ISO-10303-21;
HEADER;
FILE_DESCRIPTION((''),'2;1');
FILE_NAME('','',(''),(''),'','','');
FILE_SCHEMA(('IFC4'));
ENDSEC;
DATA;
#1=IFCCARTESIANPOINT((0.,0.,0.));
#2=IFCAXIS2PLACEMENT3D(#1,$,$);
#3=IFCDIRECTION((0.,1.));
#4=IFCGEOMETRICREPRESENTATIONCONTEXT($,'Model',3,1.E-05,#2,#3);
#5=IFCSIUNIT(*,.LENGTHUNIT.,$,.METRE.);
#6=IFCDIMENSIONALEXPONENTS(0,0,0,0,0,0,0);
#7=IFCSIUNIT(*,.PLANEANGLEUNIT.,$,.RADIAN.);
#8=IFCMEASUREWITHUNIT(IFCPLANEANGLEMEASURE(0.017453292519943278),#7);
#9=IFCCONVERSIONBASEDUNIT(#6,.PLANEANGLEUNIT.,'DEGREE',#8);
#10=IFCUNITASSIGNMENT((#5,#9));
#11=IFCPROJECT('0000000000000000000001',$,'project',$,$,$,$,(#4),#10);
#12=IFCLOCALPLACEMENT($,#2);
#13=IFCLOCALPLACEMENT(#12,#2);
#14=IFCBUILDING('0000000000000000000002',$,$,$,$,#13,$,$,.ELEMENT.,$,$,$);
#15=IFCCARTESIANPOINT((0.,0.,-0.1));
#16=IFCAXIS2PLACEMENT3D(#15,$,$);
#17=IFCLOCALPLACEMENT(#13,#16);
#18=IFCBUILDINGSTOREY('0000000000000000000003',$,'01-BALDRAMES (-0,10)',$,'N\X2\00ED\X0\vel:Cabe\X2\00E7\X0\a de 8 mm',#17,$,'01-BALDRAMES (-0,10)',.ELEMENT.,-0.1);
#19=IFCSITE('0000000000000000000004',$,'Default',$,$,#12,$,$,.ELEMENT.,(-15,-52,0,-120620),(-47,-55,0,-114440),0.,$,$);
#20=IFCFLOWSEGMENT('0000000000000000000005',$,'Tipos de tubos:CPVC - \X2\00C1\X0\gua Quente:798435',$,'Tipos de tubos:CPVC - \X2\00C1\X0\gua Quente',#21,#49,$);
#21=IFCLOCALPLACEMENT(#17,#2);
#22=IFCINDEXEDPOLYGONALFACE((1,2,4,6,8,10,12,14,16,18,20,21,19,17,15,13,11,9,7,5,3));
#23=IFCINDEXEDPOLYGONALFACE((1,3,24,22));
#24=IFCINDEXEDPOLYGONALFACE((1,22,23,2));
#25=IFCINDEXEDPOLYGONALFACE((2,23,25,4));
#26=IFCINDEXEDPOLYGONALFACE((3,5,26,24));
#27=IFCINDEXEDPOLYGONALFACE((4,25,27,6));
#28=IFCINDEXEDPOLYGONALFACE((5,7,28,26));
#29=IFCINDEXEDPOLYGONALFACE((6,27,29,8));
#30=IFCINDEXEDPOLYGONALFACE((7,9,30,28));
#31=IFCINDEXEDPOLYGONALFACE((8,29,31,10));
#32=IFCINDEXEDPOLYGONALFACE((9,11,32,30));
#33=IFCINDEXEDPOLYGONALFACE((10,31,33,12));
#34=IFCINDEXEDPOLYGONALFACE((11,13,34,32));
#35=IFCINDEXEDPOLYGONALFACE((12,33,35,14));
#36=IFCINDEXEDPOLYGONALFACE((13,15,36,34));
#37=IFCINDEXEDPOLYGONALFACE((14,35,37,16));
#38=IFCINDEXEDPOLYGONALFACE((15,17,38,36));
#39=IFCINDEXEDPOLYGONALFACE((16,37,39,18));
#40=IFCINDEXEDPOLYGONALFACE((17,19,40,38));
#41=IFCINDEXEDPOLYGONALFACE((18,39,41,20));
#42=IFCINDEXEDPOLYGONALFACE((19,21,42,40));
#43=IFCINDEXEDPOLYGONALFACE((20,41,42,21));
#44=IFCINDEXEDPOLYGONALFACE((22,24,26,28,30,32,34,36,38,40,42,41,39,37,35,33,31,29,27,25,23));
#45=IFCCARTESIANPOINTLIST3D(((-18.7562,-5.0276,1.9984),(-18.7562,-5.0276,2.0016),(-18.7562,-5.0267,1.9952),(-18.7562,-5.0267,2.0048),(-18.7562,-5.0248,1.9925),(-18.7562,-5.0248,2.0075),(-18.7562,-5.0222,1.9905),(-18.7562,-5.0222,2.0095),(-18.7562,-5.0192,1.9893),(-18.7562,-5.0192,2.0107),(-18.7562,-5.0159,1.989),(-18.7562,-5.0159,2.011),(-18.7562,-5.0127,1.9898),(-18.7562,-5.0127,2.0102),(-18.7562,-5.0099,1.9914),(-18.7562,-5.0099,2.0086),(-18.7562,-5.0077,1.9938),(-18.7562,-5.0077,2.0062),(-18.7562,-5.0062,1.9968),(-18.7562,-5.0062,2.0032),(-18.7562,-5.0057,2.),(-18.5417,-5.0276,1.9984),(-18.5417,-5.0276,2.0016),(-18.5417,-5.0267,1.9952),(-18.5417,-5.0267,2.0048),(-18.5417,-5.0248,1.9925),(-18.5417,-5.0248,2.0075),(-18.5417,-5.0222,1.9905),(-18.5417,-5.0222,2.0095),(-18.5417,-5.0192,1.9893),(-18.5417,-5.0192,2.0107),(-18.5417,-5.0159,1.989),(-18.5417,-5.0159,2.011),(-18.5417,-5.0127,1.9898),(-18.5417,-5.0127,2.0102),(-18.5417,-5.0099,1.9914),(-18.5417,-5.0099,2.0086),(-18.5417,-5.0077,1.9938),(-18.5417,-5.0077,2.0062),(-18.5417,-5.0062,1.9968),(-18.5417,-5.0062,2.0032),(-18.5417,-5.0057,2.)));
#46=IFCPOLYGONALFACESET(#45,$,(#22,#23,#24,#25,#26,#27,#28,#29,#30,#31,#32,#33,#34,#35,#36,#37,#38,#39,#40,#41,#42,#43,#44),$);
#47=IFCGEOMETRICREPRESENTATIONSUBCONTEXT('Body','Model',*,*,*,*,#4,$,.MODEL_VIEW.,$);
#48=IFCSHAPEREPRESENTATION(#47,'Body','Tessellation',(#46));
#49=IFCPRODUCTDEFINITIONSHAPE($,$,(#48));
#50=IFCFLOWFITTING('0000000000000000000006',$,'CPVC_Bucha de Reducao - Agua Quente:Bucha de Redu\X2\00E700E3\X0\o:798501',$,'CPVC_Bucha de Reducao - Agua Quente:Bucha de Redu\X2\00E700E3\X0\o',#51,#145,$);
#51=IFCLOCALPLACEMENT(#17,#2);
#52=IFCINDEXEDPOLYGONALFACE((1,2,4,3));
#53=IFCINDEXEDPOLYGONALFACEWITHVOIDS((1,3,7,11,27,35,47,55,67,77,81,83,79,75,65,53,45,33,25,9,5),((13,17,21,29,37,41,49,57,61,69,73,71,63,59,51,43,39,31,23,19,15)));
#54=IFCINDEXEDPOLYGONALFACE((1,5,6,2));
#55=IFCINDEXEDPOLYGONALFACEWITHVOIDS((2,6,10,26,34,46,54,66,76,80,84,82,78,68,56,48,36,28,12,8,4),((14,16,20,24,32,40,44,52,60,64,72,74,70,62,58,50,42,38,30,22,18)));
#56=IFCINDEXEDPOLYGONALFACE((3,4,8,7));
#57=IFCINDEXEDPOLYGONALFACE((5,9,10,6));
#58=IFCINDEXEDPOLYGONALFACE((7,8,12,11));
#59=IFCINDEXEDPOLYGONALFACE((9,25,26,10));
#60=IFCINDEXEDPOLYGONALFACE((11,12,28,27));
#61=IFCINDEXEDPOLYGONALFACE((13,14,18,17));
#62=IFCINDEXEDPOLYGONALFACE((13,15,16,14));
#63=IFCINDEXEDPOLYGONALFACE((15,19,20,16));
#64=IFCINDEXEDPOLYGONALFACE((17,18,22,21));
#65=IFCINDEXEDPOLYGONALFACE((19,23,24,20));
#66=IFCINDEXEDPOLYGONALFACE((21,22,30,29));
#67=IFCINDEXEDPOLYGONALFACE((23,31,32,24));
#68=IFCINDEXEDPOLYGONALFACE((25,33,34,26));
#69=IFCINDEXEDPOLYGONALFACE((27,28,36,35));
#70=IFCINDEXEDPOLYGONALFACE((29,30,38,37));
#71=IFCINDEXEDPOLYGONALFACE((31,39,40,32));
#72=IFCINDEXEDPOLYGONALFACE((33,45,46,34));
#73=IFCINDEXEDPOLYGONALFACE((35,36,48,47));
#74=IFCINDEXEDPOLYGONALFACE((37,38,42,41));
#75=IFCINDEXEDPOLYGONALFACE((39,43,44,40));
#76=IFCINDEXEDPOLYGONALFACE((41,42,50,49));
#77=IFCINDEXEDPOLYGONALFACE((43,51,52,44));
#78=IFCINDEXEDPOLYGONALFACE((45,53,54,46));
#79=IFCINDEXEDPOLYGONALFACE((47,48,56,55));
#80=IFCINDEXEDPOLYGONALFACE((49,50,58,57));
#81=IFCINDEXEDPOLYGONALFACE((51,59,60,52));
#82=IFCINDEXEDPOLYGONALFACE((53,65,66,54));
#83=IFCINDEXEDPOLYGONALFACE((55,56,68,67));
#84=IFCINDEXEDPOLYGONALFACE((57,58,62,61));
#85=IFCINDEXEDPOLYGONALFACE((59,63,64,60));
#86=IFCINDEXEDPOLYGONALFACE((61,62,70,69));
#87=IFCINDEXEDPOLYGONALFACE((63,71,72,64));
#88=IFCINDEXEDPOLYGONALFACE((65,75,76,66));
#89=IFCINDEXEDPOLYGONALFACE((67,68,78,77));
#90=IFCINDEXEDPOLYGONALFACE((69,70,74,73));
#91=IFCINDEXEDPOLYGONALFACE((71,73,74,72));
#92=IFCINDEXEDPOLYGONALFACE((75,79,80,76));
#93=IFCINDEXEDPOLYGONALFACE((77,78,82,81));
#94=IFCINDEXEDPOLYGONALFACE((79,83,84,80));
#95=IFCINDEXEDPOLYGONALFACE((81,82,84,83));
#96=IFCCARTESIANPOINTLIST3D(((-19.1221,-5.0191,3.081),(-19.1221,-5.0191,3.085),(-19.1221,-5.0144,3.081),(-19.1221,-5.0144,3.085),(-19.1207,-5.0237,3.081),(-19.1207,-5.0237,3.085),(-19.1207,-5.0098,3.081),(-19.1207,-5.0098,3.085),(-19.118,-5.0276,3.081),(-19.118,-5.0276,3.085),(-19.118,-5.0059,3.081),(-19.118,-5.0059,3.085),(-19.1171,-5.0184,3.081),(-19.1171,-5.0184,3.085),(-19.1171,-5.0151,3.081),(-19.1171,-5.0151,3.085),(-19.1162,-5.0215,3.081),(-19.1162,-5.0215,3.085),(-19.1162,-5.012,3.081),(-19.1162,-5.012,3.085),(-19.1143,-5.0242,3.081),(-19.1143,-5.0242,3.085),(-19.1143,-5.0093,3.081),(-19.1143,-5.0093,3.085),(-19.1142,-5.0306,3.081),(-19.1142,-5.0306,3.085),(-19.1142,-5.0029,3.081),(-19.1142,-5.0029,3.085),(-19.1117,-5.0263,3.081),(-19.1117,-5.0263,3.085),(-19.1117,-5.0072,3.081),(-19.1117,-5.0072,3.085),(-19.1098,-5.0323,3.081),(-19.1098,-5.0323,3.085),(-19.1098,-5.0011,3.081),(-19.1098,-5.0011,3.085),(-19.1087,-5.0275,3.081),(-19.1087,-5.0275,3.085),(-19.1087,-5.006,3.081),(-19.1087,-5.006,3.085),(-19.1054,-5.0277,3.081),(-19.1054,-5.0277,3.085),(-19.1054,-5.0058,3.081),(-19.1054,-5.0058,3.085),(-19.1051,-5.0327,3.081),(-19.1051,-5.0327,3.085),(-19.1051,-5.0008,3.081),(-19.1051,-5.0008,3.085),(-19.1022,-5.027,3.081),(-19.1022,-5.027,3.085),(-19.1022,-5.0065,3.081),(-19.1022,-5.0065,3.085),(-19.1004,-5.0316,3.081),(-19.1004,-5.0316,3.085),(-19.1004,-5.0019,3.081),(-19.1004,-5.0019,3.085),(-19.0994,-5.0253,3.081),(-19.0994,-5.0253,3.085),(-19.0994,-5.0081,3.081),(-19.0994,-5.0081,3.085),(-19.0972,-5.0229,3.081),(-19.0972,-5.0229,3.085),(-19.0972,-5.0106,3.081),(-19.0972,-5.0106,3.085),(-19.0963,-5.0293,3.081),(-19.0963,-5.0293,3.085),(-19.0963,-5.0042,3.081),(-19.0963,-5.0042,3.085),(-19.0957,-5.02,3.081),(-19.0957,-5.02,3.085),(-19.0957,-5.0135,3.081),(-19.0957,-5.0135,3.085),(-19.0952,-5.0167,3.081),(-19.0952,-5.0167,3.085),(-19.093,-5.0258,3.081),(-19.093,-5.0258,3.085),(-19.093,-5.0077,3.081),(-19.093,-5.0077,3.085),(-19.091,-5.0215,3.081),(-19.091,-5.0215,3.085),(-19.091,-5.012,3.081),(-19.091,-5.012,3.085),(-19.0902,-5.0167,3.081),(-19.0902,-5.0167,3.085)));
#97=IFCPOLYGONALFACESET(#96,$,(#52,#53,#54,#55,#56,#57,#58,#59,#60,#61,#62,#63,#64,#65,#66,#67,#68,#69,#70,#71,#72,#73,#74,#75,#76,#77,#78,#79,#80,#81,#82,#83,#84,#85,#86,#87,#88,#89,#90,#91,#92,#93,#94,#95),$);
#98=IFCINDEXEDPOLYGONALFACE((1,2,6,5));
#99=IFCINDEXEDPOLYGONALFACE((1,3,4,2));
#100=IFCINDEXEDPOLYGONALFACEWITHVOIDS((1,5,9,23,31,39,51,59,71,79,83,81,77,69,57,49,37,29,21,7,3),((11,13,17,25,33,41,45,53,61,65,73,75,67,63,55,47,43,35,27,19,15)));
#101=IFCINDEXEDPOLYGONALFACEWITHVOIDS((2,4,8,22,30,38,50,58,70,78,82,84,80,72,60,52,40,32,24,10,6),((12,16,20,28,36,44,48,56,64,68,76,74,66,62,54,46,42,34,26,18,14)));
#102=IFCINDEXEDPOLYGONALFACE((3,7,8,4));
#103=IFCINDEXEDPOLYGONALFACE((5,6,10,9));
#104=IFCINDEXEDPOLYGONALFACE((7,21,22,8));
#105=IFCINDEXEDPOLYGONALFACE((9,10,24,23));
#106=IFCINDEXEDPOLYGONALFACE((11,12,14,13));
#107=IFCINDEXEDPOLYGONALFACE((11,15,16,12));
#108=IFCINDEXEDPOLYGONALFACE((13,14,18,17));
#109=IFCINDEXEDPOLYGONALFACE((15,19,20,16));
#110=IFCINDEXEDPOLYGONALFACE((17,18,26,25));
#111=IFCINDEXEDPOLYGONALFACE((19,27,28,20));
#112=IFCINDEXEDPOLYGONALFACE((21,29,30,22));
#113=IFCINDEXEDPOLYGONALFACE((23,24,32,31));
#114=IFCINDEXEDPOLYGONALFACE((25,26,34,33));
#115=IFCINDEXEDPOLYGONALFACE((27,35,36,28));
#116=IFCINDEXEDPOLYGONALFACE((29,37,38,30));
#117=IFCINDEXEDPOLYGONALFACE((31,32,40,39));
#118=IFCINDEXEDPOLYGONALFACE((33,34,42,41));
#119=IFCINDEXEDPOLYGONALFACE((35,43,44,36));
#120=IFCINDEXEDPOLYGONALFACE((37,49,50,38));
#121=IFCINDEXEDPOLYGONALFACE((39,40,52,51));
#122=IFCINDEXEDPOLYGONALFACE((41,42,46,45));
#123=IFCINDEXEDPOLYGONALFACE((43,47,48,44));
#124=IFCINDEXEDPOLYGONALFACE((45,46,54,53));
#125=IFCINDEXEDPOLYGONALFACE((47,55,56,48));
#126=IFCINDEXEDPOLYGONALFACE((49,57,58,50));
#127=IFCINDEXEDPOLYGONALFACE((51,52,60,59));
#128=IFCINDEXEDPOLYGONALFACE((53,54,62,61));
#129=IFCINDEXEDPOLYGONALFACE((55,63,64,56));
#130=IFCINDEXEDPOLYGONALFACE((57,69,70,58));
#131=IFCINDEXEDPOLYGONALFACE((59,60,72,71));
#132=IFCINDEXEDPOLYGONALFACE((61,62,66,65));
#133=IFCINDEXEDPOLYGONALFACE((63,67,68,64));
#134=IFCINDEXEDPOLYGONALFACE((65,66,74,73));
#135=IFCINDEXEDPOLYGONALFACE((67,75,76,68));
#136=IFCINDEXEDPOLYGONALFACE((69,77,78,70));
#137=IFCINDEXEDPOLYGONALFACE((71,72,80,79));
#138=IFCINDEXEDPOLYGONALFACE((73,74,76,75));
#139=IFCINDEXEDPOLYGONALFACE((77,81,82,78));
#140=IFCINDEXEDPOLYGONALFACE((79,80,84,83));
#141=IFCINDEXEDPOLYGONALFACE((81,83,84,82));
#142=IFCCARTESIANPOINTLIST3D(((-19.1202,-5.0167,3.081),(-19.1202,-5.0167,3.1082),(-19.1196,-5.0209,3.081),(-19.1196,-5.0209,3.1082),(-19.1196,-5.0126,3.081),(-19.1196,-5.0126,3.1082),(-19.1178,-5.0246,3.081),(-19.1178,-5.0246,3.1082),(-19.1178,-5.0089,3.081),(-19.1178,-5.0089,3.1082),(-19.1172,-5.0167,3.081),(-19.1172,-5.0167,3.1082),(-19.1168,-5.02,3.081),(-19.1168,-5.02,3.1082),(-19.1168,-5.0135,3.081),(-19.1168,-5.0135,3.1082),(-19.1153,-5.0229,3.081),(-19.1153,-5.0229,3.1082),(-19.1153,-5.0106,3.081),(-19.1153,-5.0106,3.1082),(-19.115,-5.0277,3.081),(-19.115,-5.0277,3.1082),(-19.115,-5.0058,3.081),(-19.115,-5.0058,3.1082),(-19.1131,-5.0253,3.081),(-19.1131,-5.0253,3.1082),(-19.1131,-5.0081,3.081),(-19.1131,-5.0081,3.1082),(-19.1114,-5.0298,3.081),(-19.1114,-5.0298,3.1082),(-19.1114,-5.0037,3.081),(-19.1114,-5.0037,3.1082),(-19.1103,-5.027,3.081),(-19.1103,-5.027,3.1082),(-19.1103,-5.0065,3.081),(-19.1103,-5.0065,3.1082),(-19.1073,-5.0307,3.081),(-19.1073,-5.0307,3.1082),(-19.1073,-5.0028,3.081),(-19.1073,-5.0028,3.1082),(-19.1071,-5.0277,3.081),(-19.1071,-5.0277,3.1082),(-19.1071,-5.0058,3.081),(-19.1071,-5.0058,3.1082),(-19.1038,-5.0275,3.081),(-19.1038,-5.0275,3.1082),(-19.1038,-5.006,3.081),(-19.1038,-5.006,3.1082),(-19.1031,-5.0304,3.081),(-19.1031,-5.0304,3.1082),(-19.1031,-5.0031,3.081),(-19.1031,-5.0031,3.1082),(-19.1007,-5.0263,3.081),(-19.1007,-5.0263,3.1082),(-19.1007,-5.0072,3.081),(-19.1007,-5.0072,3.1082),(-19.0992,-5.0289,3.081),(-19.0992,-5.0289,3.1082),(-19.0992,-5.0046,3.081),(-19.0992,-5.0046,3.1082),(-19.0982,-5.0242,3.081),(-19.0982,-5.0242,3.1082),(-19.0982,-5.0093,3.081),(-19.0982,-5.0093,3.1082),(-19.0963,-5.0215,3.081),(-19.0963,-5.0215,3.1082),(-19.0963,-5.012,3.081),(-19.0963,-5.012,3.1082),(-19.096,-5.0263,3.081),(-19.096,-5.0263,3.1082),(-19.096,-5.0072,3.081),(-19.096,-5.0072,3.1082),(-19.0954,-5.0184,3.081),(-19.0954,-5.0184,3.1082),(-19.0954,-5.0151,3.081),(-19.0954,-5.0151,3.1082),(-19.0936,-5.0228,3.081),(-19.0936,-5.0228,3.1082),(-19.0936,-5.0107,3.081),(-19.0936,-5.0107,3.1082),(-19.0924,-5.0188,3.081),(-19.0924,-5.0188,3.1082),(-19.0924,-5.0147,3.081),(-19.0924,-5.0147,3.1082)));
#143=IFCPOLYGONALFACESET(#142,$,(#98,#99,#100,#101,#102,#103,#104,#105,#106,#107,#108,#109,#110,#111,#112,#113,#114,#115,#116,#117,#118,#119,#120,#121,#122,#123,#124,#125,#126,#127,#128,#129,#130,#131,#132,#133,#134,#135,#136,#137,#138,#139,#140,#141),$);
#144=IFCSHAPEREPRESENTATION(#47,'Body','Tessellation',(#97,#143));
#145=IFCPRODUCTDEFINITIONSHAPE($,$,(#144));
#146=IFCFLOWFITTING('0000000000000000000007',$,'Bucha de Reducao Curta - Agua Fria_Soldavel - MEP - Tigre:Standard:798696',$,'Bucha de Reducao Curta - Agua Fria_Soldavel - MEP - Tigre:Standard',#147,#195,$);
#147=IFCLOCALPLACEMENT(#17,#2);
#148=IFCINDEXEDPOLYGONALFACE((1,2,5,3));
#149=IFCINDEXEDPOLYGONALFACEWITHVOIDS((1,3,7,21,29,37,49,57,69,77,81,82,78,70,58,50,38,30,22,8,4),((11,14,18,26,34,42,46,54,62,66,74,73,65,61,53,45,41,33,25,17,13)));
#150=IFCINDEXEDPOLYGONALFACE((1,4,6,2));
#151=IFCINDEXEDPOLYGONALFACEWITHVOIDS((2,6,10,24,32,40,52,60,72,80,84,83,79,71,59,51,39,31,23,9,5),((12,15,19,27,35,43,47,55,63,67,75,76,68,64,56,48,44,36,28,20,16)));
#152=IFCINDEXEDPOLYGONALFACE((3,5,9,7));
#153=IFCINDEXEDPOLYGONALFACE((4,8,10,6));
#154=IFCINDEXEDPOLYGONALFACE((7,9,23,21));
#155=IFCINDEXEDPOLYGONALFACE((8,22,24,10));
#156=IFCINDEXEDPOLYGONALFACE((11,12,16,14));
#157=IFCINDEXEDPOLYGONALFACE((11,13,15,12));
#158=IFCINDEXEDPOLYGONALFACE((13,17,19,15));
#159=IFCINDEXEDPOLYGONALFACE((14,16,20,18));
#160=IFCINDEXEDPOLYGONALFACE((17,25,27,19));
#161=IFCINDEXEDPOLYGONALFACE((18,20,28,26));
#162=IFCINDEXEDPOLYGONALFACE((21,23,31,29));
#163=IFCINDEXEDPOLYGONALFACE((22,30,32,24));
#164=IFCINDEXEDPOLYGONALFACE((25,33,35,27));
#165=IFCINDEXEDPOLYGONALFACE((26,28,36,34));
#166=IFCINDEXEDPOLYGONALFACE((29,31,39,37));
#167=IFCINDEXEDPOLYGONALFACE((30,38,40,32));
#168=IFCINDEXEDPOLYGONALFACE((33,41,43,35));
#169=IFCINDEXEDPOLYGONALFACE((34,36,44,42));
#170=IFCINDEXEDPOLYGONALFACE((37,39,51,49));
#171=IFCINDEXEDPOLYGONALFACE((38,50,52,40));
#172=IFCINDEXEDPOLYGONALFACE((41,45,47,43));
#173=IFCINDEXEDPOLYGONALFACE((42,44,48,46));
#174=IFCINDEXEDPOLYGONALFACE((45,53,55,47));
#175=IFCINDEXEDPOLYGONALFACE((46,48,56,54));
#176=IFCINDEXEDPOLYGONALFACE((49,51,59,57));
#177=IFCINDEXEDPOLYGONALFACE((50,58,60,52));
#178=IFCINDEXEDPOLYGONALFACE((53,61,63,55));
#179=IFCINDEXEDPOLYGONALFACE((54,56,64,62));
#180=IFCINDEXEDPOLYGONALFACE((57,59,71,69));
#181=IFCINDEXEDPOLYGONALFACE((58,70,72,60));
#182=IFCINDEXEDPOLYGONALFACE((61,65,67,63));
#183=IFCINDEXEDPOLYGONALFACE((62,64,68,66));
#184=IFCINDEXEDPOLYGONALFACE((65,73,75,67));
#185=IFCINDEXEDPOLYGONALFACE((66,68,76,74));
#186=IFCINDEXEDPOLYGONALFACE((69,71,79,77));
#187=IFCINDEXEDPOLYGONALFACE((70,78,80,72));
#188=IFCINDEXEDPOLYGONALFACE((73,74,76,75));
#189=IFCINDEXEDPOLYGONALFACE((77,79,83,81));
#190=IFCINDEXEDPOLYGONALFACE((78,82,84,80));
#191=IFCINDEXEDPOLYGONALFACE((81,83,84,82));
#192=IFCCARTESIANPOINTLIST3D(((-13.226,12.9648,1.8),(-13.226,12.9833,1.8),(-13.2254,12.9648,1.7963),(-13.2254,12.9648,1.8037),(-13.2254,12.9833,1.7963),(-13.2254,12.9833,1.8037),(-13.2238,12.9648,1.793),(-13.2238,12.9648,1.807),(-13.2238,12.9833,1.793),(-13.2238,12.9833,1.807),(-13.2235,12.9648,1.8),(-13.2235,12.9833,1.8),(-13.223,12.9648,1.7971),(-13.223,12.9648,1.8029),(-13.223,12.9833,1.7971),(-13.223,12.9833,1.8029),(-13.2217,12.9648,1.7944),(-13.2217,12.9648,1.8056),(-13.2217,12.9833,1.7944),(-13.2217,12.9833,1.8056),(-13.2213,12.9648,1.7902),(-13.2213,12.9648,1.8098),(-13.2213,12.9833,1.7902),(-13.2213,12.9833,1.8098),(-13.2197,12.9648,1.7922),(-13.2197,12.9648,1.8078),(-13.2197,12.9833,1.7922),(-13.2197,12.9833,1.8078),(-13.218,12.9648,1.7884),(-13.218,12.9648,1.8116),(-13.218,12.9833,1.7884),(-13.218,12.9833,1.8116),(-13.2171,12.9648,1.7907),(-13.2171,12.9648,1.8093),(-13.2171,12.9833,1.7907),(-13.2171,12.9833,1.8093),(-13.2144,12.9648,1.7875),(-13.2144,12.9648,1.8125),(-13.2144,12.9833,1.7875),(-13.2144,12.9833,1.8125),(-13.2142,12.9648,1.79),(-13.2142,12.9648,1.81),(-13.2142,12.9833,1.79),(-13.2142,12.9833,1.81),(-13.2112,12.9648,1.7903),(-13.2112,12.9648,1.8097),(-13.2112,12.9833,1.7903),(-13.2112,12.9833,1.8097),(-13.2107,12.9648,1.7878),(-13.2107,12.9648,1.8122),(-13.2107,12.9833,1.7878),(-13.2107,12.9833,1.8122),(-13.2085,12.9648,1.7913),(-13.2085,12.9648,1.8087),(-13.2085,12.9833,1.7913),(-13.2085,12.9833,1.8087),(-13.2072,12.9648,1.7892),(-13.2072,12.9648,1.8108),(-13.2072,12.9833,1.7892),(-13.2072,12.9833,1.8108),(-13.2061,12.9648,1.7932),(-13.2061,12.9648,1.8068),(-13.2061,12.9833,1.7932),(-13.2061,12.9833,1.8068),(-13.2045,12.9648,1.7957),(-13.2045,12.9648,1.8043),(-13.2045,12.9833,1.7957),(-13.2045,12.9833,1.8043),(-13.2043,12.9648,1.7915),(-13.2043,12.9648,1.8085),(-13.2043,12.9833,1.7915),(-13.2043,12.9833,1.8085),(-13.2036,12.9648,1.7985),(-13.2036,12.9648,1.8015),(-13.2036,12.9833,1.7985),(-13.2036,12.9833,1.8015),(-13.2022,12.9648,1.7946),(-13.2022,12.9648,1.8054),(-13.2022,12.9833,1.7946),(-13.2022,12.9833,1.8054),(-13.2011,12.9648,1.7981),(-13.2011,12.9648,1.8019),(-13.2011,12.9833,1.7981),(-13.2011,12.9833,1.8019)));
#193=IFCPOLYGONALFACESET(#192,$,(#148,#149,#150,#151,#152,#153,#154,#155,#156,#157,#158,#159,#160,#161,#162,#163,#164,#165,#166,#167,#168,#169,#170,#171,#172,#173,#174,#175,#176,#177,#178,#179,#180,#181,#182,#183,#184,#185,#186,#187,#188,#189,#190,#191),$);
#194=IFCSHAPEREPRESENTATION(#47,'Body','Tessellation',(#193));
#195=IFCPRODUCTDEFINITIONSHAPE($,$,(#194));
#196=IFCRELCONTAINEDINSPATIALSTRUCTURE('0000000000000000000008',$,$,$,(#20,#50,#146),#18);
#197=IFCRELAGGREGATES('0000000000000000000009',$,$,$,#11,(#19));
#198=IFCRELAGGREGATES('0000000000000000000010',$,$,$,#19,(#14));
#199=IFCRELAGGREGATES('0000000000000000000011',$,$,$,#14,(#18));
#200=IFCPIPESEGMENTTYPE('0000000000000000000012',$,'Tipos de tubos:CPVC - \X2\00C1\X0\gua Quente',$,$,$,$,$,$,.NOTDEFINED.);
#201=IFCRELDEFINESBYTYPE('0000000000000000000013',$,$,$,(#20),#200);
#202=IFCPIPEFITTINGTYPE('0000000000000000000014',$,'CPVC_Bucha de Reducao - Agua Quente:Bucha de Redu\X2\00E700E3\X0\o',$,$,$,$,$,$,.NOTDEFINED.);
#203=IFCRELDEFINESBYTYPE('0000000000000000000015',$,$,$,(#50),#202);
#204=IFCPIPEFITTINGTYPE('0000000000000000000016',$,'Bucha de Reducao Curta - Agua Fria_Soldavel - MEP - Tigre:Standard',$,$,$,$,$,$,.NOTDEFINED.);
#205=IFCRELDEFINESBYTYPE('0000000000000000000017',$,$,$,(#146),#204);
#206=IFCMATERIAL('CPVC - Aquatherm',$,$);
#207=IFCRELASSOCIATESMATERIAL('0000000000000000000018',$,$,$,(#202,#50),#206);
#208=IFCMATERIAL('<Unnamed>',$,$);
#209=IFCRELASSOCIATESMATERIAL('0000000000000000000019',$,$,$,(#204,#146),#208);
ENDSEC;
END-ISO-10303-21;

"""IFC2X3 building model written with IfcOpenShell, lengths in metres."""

from ifc_helpers import new_model, entity, si_unit, converted_unit, direction, frame, frame_2d, origin, place, context, subcontext, project, spatial, circle, hollow_circle, extrude, source, transform, mapped, material, type_object, type_shapes, element, save


model = new_model("IFC2X3")

# Units and contexts
model_context = context("Model", 3, precision=1e-05, world=origin(), true_north=direction((0.0, 1.0)))
body_context = subcontext(model_context, "Body", "Model", "MODEL_VIEW")
ifc_project = project(units=[si_unit("LENGTHUNIT", "METRE"), converted_unit("PLANEANGLEUNIT", "DEGREE", entity("IfcPlaneAngleMeasure", 0.017453292519943278), si_unit("PLANEANGLEUNIT", "RADIAN"), dimensions=[0, 0, 0, 0, 0, 0, 0])], contexts=[model_context])

# Site, building, storey
site_placement = place(None, origin())
site = spatial("IfcSite", under=ifc_project, at=site_placement, Name="Default", CompositionType="ELEMENT", RefLatitude=(-15, -52, 0, -120620), RefLongitude=(-47, -55, 0, -114440), RefElevation=0.0)
building_placement = place(site_placement, origin())
building = spatial("IfcBuilding", under=site, at=building_placement, CompositionType="ELEMENT")
storey_placement = place(building_placement, frame((0.0, 0.0, -0.1)))
storey = spatial("IfcBuildingStorey", under=building, at=storey_placement, Name="01-BALDRAMES (-0,10)", ObjectType="Nível:Cabeça de 8 mm", LongName="01-BALDRAMES (-0,10)", CompositionType="ELEMENT", Elevation=-0.1)

# Flow segment
pipe_segment_type_1 = type_object("IfcPipeSegmentType", Name="Tipos de tubos:CPVC - Água Quente", PredefinedType="NOTDEFINED")
flow_segment_1_placement = place(storey_placement, origin())
element("IfcFlowSegment", 1, at=flow_segment_1_placement, inside=storey, type_object=pipe_segment_type_1, Name="Tipos de tubos:CPVC - Água Quente:798435", ObjectType="Tipos de tubos:CPVC - Água Quente", context=body_context, shape_type="SweptSolid", body=[
    extrude(circle(Radius=0.011, at=frame_2d((0.0, 0.0), x_axis=(1.0, 0.0))), frame((-18.7562, -5.0167, 2.0), z_axis=(1.0, 0.0, 0.0), x_axis=(0.0, 1.0, 0.0)), (0.0, 0.0, 1.0), 0.2145),
])

# Flow fittings
ifc_material_1 = material(Name="CPVC - Aquatherm")
pipe_fitting_type_1 = type_object("IfcPipeFittingType", Name="CPVC_Bucha de Reducao - Agua Quente:Bucha de Redução", PredefinedType="NOTDEFINED", material=ifc_material_1)
shared_shape_1 = source(origin(), body_context, "Body", "SweptSolid", [
    extrude(hollow_circle(Radius=0.016, WallThickness=0.005, at=frame_2d((0.0, 0.0), x_axis=(1.0, 0.0))), frame((0.0, 0.0, 0.0), z_axis=(1.0, 0.0, 0.0), x_axis=(0.0, 1.0, 0.0)), (0.0, 0.0, 1.0), 0.004),
    extrude(hollow_circle(Radius=0.014, WallThickness=0.003, at=frame_2d((0.0, 0.0), x_axis=(1.0, 0.0))), frame((0.0, 0.0, 0.0), z_axis=(1.0, 0.0, 0.0), x_axis=(0.0, -1.0, 0.0)), (0.0, 0.0, 1.0), 0.0272),
])
type_shapes(pipe_fitting_type_1, [shared_shape_1])
flow_fitting_1_placement = place(storey_placement, frame((-19.1062, -5.0167, 3.081), z_axis=(0.0, 1.0, 0.0), x_axis=(0.0, 0.0, 1.0)))
element("IfcFlowFitting", 2, at=flow_fitting_1_placement, inside=storey, type_object=pipe_fitting_type_1, material=ifc_material_1, Name="CPVC_Bucha de Reducao - Agua Quente:Bucha de Redução:798501", ObjectType="CPVC_Bucha de Reducao - Agua Quente:Bucha de Redução", context=body_context, shape_type="MappedRepresentation", body=[
    mapped(shared_shape_1, transform((0.0, 0.0, 0.0), scale=1.0)),
])
ifc_material_2 = material(Name="<Unnamed>")
pipe_fitting_type_2 = type_object("IfcPipeFittingType", Name="Bucha de Reducao Curta - Agua Fria_Soldavel - MEP - Tigre:Standard", PredefinedType="NOTDEFINED", material=ifc_material_2)
shared_shape_2 = source(origin(), body_context, "Body", "SweptSolid", [
    extrude(hollow_circle(Radius=0.0125, WallThickness=0.0025, at=frame_2d((0.0, 0.0), x_axis=(1.0, 0.0))), frame((0.0, 0.0, 0.0), z_axis=(1.0, 0.0, 0.0), x_axis=(0.0, 1.0, 0.0)), (0.0, 0.0, 1.0), 0.0185),
])
type_shapes(pipe_fitting_type_2, [shared_shape_2])
flow_fitting_2_placement = place(storey_placement, frame((-13.2135, 12.9648, 1.8), z_axis=(0.0, 0.0, 1.0), x_axis=(0.0, 1.0, 0.0)))
element("IfcFlowFitting", 3, at=flow_fitting_2_placement, inside=storey, type_object=pipe_fitting_type_2, material=ifc_material_2, Name="Bucha de Reducao Curta - Agua Fria_Soldavel - MEP - Tigre:Standard:798696", ObjectType="Bucha de Reducao Curta - Agua Fria_Soldavel - MEP - Tigre:Standard", context=body_context, shape_type="MappedRepresentation", body=[
    mapped(shared_shape_2, transform((0.0, 0.0, 0.0), scale=1.0)),
])

save(model, "model.ifc")
